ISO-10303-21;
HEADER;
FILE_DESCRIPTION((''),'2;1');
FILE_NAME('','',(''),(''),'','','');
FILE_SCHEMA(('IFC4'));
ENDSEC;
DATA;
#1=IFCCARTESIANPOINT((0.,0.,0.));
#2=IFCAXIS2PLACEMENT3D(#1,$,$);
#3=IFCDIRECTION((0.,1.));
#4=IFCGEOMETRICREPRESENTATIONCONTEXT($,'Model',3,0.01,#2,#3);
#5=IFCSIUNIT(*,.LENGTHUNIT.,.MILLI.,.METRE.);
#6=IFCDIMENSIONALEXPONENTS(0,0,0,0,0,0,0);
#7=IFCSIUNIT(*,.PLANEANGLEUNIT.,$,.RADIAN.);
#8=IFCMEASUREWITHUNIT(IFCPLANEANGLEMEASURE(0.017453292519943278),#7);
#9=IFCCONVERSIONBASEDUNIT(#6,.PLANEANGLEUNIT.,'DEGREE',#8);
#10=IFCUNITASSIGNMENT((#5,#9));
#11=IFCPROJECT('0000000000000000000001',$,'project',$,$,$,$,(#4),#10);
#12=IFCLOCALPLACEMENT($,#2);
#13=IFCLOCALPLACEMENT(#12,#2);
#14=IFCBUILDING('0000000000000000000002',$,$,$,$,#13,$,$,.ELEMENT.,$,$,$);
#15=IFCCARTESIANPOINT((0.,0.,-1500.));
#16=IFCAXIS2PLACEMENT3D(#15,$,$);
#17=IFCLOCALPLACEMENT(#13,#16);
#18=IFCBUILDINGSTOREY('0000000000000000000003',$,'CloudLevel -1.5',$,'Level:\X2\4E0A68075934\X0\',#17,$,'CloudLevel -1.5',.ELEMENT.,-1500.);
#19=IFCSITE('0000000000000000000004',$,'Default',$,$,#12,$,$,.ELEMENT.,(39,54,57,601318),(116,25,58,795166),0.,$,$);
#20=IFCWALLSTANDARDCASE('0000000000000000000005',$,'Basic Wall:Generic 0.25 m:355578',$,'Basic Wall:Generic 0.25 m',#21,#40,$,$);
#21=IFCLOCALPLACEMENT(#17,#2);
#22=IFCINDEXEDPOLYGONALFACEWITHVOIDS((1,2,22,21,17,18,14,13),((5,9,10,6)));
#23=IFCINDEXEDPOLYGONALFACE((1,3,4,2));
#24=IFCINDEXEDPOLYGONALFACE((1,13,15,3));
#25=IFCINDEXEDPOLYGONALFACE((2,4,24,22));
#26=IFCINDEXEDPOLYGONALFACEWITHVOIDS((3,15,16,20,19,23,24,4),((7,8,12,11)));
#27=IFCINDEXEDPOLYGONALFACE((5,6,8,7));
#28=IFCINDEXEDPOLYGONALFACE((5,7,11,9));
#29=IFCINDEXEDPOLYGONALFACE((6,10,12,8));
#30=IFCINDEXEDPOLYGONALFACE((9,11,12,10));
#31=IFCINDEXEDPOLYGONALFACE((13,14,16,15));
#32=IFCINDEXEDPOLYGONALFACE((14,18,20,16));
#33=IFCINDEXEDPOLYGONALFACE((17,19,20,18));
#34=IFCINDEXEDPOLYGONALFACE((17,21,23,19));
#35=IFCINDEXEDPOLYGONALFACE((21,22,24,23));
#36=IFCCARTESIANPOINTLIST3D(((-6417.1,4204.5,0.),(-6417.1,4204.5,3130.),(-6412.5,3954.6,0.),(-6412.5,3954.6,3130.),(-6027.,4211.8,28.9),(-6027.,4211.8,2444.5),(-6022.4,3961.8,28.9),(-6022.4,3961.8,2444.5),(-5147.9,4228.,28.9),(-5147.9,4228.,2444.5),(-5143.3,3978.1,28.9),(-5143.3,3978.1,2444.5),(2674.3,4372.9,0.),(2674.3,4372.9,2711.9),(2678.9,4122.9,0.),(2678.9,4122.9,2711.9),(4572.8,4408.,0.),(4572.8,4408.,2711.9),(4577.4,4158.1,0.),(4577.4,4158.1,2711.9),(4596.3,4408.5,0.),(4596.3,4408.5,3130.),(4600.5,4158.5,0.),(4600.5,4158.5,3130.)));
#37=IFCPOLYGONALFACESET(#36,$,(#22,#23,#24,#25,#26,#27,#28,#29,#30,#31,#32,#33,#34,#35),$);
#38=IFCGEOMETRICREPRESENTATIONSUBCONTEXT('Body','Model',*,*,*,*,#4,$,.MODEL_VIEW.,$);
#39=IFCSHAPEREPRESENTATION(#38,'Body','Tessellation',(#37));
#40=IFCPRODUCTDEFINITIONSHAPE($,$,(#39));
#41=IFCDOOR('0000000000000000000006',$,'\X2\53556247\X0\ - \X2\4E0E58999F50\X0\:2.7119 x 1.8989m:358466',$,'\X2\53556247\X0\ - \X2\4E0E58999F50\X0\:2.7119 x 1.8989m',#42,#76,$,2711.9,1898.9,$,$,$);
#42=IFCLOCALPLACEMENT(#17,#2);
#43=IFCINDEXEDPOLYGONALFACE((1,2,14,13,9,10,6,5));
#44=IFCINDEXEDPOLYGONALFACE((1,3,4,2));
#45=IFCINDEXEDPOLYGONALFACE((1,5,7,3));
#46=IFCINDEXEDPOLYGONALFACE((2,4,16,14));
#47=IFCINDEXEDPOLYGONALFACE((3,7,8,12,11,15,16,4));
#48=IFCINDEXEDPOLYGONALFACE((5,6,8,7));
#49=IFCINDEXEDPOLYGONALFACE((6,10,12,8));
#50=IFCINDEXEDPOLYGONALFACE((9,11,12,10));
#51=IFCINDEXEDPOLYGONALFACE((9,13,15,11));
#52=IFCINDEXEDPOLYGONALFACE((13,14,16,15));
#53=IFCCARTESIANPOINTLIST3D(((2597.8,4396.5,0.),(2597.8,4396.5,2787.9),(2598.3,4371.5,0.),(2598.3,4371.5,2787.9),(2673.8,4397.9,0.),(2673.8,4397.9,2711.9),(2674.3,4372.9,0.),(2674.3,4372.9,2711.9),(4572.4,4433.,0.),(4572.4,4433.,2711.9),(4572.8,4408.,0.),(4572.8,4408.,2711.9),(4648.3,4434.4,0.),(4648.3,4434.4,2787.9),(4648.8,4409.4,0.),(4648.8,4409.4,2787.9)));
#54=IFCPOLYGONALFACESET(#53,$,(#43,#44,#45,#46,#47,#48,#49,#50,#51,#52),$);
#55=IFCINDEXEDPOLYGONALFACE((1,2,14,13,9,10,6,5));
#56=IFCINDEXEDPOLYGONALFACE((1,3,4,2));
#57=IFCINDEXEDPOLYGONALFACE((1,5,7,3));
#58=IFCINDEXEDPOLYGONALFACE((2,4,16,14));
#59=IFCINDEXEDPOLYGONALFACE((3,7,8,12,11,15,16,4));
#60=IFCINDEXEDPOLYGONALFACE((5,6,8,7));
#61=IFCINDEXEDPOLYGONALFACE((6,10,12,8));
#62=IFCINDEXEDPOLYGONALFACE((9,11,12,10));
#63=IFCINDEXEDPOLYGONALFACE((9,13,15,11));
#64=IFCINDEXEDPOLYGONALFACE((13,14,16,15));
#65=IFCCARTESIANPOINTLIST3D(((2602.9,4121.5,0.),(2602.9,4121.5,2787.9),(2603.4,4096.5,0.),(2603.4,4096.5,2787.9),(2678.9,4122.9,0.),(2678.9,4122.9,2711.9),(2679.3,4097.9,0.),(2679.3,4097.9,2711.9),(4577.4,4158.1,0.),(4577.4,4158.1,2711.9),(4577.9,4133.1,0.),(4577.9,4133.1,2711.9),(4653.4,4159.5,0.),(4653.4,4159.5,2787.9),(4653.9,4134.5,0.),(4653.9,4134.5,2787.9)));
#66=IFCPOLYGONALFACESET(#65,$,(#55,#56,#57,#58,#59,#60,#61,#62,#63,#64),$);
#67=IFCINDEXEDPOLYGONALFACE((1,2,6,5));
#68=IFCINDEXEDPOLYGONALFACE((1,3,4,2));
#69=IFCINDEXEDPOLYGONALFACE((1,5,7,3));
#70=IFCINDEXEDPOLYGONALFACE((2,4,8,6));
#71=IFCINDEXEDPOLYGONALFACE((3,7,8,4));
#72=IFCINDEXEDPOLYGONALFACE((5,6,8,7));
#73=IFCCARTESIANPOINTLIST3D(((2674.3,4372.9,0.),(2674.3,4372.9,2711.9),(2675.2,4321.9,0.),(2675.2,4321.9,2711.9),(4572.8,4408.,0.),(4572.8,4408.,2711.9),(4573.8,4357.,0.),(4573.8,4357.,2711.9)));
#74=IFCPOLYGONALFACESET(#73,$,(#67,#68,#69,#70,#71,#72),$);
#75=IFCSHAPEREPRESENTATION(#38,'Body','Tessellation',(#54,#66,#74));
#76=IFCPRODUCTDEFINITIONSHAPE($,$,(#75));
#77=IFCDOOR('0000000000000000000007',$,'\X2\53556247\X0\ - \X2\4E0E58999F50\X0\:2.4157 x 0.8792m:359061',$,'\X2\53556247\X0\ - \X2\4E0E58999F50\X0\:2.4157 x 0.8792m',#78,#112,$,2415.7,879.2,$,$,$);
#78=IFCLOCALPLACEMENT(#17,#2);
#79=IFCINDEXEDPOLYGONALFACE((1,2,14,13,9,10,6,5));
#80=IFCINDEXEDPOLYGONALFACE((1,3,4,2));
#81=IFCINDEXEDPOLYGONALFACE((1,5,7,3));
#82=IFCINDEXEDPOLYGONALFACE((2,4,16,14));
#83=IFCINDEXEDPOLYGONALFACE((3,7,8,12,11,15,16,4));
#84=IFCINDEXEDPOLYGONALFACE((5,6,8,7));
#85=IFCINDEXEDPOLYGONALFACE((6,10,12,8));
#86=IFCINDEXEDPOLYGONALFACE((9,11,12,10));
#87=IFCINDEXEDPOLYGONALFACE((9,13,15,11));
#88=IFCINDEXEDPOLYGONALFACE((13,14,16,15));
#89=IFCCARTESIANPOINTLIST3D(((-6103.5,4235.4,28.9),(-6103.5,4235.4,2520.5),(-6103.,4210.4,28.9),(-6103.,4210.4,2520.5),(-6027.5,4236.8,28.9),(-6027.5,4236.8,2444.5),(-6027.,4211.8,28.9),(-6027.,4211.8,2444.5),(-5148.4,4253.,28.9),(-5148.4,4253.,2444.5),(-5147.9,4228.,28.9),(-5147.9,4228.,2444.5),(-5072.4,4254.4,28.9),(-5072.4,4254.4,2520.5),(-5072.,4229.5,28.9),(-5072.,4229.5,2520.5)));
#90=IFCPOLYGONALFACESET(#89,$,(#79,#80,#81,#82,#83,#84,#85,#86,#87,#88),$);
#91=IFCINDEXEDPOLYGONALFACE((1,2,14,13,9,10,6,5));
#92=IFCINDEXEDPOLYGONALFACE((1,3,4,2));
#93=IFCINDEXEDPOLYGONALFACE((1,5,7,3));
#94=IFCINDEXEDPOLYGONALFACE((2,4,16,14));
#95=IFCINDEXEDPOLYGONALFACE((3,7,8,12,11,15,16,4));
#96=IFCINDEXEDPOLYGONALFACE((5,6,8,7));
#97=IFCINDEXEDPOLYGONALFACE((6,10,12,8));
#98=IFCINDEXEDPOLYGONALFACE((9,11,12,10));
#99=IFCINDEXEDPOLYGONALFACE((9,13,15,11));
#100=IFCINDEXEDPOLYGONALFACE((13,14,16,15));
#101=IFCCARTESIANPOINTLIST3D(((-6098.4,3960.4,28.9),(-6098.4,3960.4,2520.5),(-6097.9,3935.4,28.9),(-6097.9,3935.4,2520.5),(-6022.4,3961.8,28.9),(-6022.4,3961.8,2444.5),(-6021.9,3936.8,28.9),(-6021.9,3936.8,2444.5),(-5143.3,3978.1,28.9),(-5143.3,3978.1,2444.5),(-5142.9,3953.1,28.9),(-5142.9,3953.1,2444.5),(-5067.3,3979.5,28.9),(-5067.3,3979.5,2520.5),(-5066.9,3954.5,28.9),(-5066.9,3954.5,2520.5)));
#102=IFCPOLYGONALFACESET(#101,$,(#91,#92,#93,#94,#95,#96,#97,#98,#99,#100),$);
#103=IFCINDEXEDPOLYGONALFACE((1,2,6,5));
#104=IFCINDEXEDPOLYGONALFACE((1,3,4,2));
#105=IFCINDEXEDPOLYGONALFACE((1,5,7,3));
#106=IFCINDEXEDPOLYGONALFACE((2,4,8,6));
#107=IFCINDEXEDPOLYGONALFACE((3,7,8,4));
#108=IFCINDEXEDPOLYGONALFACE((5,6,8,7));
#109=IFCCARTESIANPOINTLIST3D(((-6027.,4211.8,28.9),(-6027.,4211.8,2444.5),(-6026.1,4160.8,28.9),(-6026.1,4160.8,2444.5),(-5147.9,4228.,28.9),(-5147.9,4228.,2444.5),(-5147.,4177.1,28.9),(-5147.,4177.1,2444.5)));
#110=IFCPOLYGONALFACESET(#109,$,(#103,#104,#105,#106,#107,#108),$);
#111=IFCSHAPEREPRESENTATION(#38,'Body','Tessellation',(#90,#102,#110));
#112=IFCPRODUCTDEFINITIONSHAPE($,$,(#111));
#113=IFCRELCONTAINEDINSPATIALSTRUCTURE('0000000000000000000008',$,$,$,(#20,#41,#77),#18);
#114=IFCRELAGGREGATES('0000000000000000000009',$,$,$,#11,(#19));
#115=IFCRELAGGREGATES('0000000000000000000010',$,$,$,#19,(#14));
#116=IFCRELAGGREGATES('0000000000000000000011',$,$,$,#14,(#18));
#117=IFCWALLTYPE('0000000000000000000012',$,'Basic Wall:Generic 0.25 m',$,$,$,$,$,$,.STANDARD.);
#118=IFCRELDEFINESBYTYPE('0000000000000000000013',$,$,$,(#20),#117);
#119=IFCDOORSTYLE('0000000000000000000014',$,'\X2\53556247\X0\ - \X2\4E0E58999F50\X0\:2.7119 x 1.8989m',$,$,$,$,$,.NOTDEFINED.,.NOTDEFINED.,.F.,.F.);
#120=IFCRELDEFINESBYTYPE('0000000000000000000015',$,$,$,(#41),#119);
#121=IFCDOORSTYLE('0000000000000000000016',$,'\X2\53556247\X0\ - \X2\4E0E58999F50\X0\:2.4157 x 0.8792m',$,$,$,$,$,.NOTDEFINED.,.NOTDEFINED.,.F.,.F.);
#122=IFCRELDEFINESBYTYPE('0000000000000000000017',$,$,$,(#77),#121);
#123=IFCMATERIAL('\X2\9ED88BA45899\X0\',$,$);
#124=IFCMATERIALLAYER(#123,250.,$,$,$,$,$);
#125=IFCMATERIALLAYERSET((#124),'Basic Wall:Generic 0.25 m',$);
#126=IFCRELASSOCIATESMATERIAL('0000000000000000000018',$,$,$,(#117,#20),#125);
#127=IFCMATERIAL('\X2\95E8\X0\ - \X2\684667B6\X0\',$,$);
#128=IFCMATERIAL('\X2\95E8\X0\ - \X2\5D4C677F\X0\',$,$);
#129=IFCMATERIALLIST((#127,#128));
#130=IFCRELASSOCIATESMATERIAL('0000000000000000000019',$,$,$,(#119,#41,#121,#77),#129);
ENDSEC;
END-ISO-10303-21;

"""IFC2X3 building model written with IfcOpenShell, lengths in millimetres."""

from ifc_helpers import new_model, entity, si_unit, converted_unit, direction, frame, frame_2d, origin, place, context, subcontext, project, spatial, polyline, rectangle, outline, extrude, source, transform, mapped, material, material_list, layer, layer_set, layer_usage, type_object, type_shapes, element, fill, save


model = new_model("IFC2X3")

# Units and contexts
model_context = context("Model", 3, precision=0.01, world=origin(), true_north=direction((0.0, 1.0)))
body_context = subcontext(model_context, "Body", "Model", "MODEL_VIEW")
ifc_project = project(units=[si_unit("LENGTHUNIT", "METRE", prefix="MILLI"), converted_unit("PLANEANGLEUNIT", "DEGREE", entity("IfcPlaneAngleMeasure", 0.017453292519943278), si_unit("PLANEANGLEUNIT", "RADIAN"), dimensions=[0, 0, 0, 0, 0, 0, 0])], contexts=[model_context])

# Site, building, storey
site_placement = place(None, origin())
site = spatial("IfcSite", under=ifc_project, at=site_placement, Name="Default", CompositionType="ELEMENT", RefLatitude=(39, 54, 57, 601318), RefLongitude=(116, 25, 58, 795166), RefElevation=0.0)
building_placement = place(site_placement, origin())
building = spatial("IfcBuilding", under=site, at=building_placement, CompositionType="ELEMENT")
storey_placement = place(building_placement, frame((0.0, 0.0, -1500.0)))
storey = spatial("IfcBuildingStorey", under=building, at=storey_placement, Name="CloudLevel -1.5", ObjectType="Level:上标头", LongName="CloudLevel -1.5", CompositionType="ELEMENT", Elevation=-1500.0)

# Shared definitions
ifc_material_1 = material(Name="默认墙")
ifc_material_2 = material(Name="门 - 框架")
ifc_material_3 = material(Name="门 - 嵌板")
ifc_material_list = material_list([ifc_material_2, ifc_material_3])

# Wall, openings, doors
ifc_layer_1 = layer(ifc_material_1, 250.0)
ifc_layer_set_1 = layer_set([ifc_layer_1], Name="Basic Wall:Generic 0.25 m")
ifc_layer_usage_1 = layer_usage(ifc_layer_set_1, "AXIS2", "NEGATIVE", 125.0)
wall_type_1 = type_object("IfcWallType", Name="Basic Wall:Generic 0.25 m", PredefinedType="STANDARD", material=ifc_layer_set_1)
wall_1_placement = place(storey_placement, frame((4598.7, 4283.5, 0.0), z_axis=(0.0, 0.0, 1.0), x_axis=(-0.999829, -0.018511, 0.0)))
wall_1 = element("IfcWallStandardCase", 1, at=wall_1_placement, inside=storey, type_object=wall_type_1, material=ifc_layer_usage_1, Name="Basic Wall:Generic 0.25 m:355578", ObjectType="Basic Wall:Generic 0.25 m", context=body_context, shape_type="SweptSolid", body=[
    extrude(outline(polyline([(0.0, -125.0), (2020.1, -125.0), (2260.1, -125.0), (8124.6, -125.0), (8364.6, -125.0), (9500.5, -125.0), (9740.6, -125.0), (11015.4, -125.0), (11015.4, 125.0), (8064.7, 125.0), (7784.7, 125.0), (0.5, 125.0), (0.0, -125.0)])), origin(), (0.0, 0.0, 1.0), 3130.0),
])
opening_1_placement = place(wall_1_placement, frame((1922.4, 125.0, 0.0)))
opening_1 = element("IfcOpeningElement", 2, at=opening_1_placement, cuts=wall_1, ObjectType="Opening", context=body_context, shape_type="SweptSolid", body=[
    extrude(rectangle(XDim=1898.9, YDim=2711.9, at=frame_2d((1355.9, 949.4), x_axis=(0.0, -1.0))), frame((0.0, 0.0, 0.0), z_axis=(0.0, -1.0, 0.0), x_axis=(0.0, 0.0, 1.0)), (0.0, 0.0, 1.0), 250.0),
])
opening_2_placement = place(wall_1_placement, frame((10625.2, 125.0, 28.9)))
opening_2 = element("IfcOpeningElement", 3, at=opening_2_placement, cuts=wall_1, ObjectType="Opening", context=body_context, shape_type="SweptSolid", body=[
    extrude(rectangle(XDim=879.2, YDim=2415.7, at=frame_2d((1207.8, 439.6), x_axis=(0.0, -1.0))), frame((0.0, 0.0, 0.0), z_axis=(0.0, -1.0, 0.0), x_axis=(0.0, 0.0, 1.0)), (0.0, 0.0, 1.0), 250.0),
])
door_style_1 = type_object("IfcDoorStyle", Name="单扇 - 与墙齐:2.7119 x 1.8989m", ConstructionType="NOTDEFINED", OperationType="NOTDEFINED", ParameterTakesPrecedence=False, Sizeable=False, material=ifc_material_list)
shared_shape_1 = source(origin(), body_context, "Body", "SweptSolid", [
    extrude(outline(polyline([(-1025.4, -1412.9), (1025.4, -1412.9), (1025.4, 1374.9), (949.4, 1374.9), (949.4, -1336.9), (-949.4, -1336.9), (-949.4, 1374.9), (-1025.4, 1374.9), (-1025.4, -1412.9)])), frame((949.4, 275.0, 1374.9), z_axis=(0.0, -1.0, 0.0), x_axis=(-1.0, 0.0, 0.0)), (0.0, 0.0, 1.0), 25.0),
    extrude(outline(polyline([(-1412.9, -1025.4), (1374.9, -1025.4), (1374.9, -949.4), (-1336.9, -949.4), (-1336.9, 949.4), (1374.9, 949.4), (1374.9, 1025.4), (-1412.9, 1025.4), (-1412.9, -1025.4)])), frame((949.4, 0.0, 1374.9), z_axis=(0.0, -1.0, 0.0), x_axis=(0.0, 0.0, -1.0)), (0.0, 0.0, 1.0), 25.0),
    extrude(rectangle(XDim=1898.9, YDim=51.0, at=frame_2d((0.0, 0.0), x_axis=(1.0, 0.0))), frame((949.4, 224.5, 0.0)), (0.0, 0.0, 1.0), 2711.9),
])
type_shapes(door_style_1, [shared_shape_1])
door_1_placement = place(opening_1_placement, frame((0.0, 0.0, 0.0), z_axis=(0.0, 0.0, 1.0), x_axis=(-1.0, 0.0, 0.0)))
door_1 = element("IfcDoor", 4, at=door_1_placement, inside=storey, type_object=door_style_1, material=ifc_material_list, Name="单扇 - 与墙齐:2.7119 x 1.8989m:358466", ObjectType="单扇 - 与墙齐:2.7119 x 1.8989m", OverallHeight=2711.9, OverallWidth=1898.9, context=body_context, shape_type="MappedRepresentation", body=[
    mapped(shared_shape_1, transform((0.0, 0.0, 0.0), scale=1.0)),
])
fill(opening_1, door_1)
door_style_2 = type_object("IfcDoorStyle", Name="单扇 - 与墙齐:2.4157 x 0.8792m", ConstructionType="NOTDEFINED", OperationType="NOTDEFINED", ParameterTakesPrecedence=False, Sizeable=False, material=ifc_material_list)
shared_shape_2 = source(origin(), body_context, "Body", "SweptSolid", [
    extrude(outline(polyline([(-515.6, -1264.8), (515.6, -1264.8), (515.6, 1226.8), (439.6, 1226.8), (439.6, -1188.8), (-439.6, -1188.8), (-439.6, 1226.8), (-515.6, 1226.8), (-515.6, -1264.8)])), frame((439.6, 275.0, 1226.8), z_axis=(0.0, -1.0, 0.0), x_axis=(-1.0, 0.0, 0.0)), (0.0, 0.0, 1.0), 25.0),
    extrude(outline(polyline([(-1264.8, -515.6), (1226.8, -515.6), (1226.8, -439.6), (-1188.8, -439.6), (-1188.8, 439.6), (1226.8, 439.6), (1226.8, 515.6), (-1264.8, 515.6), (-1264.8, -515.6)])), frame((439.6, 0.0, 1226.8), z_axis=(0.0, -1.0, 0.0), x_axis=(0.0, 0.0, -1.0)), (0.0, 0.0, 1.0), 25.0),
    extrude(rectangle(XDim=879.2, YDim=51.0, at=frame_2d((0.0, 0.0), x_axis=(1.0, 0.0))), frame((439.6, 224.5, 0.0)), (0.0, 0.0, 1.0), 2415.7),
])
type_shapes(door_style_2, [shared_shape_2])
door_2_placement = place(opening_2_placement, frame((0.0, 0.0, 0.0), z_axis=(0.0, 0.0, 1.0), x_axis=(-1.0, 0.0, 0.0)))
door_2 = element("IfcDoor", 5, at=door_2_placement, inside=storey, type_object=door_style_2, material=ifc_material_list, Name="单扇 - 与墙齐:2.4157 x 0.8792m:359061", ObjectType="单扇 - 与墙齐:2.4157 x 0.8792m", OverallHeight=2415.7, OverallWidth=879.2, context=body_context, shape_type="MappedRepresentation", body=[
    mapped(shared_shape_2, transform((0.0, 0.0, 0.0), scale=1.0)),
])
fill(opening_2, door_2)

save(model, "model.ifc")
